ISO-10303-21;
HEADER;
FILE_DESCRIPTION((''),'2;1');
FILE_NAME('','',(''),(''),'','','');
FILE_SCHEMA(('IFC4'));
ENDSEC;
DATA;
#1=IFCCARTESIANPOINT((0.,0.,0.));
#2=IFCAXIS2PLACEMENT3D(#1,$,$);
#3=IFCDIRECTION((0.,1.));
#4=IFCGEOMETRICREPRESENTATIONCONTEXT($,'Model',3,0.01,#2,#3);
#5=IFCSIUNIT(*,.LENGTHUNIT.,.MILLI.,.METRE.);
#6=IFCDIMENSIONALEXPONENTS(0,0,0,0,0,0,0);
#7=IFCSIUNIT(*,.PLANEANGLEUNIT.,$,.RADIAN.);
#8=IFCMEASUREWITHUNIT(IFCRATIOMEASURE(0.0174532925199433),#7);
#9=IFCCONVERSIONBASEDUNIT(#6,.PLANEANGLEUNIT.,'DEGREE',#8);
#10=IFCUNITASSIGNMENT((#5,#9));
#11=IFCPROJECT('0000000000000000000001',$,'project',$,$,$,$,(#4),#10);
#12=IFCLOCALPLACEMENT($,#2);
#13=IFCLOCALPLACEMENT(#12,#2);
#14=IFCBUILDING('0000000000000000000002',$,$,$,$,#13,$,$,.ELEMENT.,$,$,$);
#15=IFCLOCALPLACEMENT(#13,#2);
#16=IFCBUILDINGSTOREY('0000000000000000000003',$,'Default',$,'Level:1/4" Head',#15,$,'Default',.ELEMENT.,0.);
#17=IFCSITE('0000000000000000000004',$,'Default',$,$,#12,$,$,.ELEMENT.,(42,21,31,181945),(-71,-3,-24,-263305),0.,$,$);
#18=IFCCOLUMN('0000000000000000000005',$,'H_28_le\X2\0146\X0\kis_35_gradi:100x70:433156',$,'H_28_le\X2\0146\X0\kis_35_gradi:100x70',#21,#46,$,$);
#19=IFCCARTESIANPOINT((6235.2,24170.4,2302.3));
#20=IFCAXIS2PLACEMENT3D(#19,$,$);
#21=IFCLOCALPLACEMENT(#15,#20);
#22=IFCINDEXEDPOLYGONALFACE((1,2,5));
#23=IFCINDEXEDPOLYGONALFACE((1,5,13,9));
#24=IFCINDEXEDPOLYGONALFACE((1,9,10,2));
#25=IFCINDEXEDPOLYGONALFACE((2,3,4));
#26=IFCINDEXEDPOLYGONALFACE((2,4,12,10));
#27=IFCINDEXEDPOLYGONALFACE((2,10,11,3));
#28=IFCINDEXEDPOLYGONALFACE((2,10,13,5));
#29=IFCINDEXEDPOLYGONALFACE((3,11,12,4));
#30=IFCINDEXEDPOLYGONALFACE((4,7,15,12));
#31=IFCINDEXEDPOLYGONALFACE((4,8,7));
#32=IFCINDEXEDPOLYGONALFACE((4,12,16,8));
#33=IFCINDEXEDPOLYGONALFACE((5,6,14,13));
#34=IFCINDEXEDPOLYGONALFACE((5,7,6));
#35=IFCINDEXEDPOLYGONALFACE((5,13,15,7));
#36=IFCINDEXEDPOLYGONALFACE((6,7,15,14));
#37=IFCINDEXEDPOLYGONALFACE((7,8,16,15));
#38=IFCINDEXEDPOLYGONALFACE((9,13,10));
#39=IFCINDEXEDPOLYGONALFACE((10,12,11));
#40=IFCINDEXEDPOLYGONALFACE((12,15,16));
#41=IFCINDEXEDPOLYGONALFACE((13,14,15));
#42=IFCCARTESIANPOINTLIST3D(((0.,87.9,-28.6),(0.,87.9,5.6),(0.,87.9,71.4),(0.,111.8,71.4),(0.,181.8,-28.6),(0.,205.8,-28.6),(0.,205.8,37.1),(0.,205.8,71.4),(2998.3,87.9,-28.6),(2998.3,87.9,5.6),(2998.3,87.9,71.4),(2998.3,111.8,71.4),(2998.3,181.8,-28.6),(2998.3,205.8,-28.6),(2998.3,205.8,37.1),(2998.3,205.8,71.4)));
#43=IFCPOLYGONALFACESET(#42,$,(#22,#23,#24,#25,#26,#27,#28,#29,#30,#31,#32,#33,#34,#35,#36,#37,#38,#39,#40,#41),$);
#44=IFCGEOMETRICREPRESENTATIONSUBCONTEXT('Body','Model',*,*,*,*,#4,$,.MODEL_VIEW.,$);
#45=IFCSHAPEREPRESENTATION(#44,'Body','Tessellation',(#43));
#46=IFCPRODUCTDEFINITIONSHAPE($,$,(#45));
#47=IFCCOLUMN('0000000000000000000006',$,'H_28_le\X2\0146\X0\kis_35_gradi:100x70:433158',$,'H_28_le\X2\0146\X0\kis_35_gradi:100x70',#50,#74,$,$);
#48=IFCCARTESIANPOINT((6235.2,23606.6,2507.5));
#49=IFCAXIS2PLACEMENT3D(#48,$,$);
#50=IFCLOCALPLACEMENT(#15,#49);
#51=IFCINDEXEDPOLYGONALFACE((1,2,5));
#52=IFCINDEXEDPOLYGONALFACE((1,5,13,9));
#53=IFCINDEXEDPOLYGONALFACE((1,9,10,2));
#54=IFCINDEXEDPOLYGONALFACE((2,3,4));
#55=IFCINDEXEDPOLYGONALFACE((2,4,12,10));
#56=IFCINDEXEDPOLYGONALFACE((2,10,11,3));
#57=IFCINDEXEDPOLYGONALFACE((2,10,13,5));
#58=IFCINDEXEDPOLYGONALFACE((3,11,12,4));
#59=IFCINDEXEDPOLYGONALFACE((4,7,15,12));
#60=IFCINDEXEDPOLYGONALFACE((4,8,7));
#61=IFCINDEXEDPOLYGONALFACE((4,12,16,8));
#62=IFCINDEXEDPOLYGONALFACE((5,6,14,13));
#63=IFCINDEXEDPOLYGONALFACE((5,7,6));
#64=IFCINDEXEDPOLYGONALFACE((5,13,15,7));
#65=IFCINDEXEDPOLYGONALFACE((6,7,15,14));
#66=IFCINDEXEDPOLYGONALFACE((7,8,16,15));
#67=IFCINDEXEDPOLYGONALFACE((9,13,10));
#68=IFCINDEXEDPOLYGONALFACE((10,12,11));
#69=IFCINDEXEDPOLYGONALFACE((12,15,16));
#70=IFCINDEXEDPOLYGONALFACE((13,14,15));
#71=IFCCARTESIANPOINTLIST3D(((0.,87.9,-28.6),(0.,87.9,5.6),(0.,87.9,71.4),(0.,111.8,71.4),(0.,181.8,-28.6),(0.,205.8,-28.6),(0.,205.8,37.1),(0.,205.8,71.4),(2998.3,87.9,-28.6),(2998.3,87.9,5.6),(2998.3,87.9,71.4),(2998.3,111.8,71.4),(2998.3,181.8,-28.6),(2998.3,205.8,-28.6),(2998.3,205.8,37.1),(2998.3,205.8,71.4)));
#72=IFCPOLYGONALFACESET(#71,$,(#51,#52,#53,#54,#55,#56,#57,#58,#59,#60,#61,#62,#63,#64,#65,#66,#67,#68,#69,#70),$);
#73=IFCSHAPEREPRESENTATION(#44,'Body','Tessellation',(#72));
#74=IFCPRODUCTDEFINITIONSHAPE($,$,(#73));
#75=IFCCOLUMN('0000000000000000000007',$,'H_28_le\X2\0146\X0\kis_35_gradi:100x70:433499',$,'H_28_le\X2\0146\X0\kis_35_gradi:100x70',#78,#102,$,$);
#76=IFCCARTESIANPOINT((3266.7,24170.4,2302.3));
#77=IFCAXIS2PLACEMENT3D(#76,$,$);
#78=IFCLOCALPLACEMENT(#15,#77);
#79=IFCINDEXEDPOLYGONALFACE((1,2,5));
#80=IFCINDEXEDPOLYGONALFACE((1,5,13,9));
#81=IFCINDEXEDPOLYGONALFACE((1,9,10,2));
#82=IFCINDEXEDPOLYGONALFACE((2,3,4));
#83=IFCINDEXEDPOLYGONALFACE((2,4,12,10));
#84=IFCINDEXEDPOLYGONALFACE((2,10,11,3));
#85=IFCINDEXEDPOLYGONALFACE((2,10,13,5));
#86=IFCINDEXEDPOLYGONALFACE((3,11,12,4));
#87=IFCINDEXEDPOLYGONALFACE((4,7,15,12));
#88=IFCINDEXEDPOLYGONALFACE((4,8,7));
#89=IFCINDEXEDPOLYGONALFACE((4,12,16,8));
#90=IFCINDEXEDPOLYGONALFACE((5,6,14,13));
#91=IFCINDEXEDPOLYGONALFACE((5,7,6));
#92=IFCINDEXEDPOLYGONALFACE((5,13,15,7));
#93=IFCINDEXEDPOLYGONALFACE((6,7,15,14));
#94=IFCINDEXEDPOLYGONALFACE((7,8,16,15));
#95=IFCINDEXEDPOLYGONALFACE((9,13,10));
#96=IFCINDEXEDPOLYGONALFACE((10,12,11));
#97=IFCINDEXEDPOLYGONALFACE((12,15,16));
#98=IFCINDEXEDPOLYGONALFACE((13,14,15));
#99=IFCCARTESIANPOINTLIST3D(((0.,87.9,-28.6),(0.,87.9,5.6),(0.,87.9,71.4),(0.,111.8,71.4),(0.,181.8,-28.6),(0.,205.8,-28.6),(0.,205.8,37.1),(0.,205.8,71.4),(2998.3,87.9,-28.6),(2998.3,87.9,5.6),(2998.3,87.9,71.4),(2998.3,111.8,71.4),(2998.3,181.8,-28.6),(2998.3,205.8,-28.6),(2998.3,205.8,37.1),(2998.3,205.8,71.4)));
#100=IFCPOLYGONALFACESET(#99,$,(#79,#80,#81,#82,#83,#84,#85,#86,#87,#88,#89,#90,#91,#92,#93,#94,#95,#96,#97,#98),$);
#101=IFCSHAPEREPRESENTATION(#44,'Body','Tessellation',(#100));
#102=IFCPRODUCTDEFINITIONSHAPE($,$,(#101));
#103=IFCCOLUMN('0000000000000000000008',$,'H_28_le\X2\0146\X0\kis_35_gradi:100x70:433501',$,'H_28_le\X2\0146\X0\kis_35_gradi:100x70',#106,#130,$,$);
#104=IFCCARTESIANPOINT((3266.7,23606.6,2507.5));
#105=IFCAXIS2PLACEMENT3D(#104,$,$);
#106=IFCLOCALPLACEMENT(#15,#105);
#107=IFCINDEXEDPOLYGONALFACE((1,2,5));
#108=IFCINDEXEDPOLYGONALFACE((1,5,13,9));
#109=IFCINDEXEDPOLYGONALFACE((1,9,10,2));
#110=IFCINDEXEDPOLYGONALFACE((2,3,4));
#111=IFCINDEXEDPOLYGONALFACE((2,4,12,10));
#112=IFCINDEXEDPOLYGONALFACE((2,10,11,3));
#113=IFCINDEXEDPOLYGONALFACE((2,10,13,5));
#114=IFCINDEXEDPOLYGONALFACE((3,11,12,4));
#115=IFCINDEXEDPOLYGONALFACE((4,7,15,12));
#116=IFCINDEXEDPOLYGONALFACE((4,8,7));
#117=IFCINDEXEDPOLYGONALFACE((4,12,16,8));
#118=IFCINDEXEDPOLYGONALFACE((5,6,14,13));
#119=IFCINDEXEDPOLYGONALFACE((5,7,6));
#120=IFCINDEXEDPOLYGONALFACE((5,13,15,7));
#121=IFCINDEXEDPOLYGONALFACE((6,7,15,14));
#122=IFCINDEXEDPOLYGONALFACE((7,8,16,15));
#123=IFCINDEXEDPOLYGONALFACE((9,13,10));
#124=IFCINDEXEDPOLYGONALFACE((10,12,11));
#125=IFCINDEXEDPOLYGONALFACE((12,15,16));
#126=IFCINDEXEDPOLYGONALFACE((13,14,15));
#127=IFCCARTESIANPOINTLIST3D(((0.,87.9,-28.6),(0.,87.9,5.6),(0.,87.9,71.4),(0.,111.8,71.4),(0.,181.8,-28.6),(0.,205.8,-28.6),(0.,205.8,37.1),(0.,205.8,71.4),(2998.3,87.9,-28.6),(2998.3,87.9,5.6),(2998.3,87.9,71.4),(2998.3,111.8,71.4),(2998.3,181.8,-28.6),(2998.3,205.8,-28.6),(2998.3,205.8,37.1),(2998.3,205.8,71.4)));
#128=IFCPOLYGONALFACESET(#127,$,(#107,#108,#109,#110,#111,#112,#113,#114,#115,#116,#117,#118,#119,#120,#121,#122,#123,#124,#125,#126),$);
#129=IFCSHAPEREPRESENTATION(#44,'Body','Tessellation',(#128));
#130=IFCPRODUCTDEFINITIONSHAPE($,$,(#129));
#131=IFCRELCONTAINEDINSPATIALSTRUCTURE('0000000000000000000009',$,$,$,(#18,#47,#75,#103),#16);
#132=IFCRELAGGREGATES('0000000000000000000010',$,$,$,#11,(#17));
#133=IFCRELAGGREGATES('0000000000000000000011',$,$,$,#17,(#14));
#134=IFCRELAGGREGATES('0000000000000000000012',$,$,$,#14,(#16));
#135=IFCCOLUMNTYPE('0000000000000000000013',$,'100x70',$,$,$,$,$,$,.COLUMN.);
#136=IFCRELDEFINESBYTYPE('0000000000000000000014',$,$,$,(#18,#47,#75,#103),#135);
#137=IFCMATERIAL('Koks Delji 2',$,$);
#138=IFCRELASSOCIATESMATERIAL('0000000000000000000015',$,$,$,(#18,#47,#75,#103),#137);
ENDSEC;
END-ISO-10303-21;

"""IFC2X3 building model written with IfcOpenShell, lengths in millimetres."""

from ifc_helpers import new_model, entity, si_unit, converted_unit, direction, frame, frame_2d, origin, place, context, subcontext, project, spatial, rectangle, extrude, boolean, source, transform, mapped, material, type_object, type_shapes, element, save


model = new_model("IFC2X3")

# Units and contexts
model_context = context("Model", 3, precision=0.01, world=origin(), true_north=direction((0.0, 1.0)))
body_context = subcontext(model_context, "Body", "Model", "MODEL_VIEW")
ifc_project = project(units=[si_unit("LENGTHUNIT", "METRE", prefix="MILLI"), converted_unit("PLANEANGLEUNIT", "DEGREE", entity("IfcRatioMeasure", 0.0174532925199433), si_unit("PLANEANGLEUNIT", "RADIAN"), dimensions=[0, 0, 0, 0, 0, 0, 0])], contexts=[model_context])

# Site, building, storey
site_placement = place(None, origin())
site = spatial("IfcSite", under=ifc_project, at=site_placement, Name="Default", CompositionType="ELEMENT", RefLatitude=(42, 21, 31, 181945), RefLongitude=(-71, -3, -24, -263305), RefElevation=0.0)
building_placement = place(site_placement, origin())
building = spatial("IfcBuilding", under=site, at=building_placement, CompositionType="ELEMENT")
storey_placement = place(building_placement, origin())
storey = spatial("IfcBuildingStorey", under=building, at=storey_placement, Name="Default", ObjectType="Level:1/4\" Head", LongName="Default", CompositionType="ELEMENT", Elevation=0.0)

# Columns
ifc_material_1 = material(Name="Koks Delji 2")
column_type = type_object("IfcColumnType", Name="100x70", PredefinedType="COLUMN")
shared_shape_1 = source(origin(), body_context, "Body", "CSG", [
    boolean("DIFFERENCE", extrude(rectangle(XDim=2998.3, YDim=117.9, at=frame_2d((0.0, 0.0), x_axis=(1.0, 0.0))), frame((1499.1, 146.8, -28.6)), (0.0, 0.0, 1.0), 100.0), extrude(rectangle(XDim=70.0, YDim=100.0, at=frame_2d((0.0, 0.0), x_axis=(0.0, 1.0))), frame((2998.3, 146.8, 21.4), z_axis=(1.0, 0.0, 0.0), x_axis=(0.0, 0.939693, -0.34202)), (0.0, 0.0, -1.0), 2998.3)),
])
type_shapes(column_type, [shared_shape_1])
for number, where, name in (
    (1, (6235.2, 24170.4, 2302.3), "H_28_leņkis_35_gradi:100x70:433156"),
    (2, (6235.2, 23606.6, 2507.5), "H_28_leņkis_35_gradi:100x70:433158"),
    (3, (3266.7, 24170.4, 2302.3), "H_28_leņkis_35_gradi:100x70:433499"),
    (4, (3266.7, 23606.6, 2507.5), "H_28_leņkis_35_gradi:100x70:433501"),
):
    element("IfcColumn", number, at=place(storey_placement, frame(where)), inside=storey, type_object=column_type, material=ifc_material_1, Name=name, ObjectType="H_28_leņkis_35_gradi:100x70", context=body_context, shape_type="MappedRepresentation", body=[
        mapped(shared_shape_1, transform((0.0, 0.0, 0.0), scale=1.0)),
    ])

save(model, "model.ifc")
